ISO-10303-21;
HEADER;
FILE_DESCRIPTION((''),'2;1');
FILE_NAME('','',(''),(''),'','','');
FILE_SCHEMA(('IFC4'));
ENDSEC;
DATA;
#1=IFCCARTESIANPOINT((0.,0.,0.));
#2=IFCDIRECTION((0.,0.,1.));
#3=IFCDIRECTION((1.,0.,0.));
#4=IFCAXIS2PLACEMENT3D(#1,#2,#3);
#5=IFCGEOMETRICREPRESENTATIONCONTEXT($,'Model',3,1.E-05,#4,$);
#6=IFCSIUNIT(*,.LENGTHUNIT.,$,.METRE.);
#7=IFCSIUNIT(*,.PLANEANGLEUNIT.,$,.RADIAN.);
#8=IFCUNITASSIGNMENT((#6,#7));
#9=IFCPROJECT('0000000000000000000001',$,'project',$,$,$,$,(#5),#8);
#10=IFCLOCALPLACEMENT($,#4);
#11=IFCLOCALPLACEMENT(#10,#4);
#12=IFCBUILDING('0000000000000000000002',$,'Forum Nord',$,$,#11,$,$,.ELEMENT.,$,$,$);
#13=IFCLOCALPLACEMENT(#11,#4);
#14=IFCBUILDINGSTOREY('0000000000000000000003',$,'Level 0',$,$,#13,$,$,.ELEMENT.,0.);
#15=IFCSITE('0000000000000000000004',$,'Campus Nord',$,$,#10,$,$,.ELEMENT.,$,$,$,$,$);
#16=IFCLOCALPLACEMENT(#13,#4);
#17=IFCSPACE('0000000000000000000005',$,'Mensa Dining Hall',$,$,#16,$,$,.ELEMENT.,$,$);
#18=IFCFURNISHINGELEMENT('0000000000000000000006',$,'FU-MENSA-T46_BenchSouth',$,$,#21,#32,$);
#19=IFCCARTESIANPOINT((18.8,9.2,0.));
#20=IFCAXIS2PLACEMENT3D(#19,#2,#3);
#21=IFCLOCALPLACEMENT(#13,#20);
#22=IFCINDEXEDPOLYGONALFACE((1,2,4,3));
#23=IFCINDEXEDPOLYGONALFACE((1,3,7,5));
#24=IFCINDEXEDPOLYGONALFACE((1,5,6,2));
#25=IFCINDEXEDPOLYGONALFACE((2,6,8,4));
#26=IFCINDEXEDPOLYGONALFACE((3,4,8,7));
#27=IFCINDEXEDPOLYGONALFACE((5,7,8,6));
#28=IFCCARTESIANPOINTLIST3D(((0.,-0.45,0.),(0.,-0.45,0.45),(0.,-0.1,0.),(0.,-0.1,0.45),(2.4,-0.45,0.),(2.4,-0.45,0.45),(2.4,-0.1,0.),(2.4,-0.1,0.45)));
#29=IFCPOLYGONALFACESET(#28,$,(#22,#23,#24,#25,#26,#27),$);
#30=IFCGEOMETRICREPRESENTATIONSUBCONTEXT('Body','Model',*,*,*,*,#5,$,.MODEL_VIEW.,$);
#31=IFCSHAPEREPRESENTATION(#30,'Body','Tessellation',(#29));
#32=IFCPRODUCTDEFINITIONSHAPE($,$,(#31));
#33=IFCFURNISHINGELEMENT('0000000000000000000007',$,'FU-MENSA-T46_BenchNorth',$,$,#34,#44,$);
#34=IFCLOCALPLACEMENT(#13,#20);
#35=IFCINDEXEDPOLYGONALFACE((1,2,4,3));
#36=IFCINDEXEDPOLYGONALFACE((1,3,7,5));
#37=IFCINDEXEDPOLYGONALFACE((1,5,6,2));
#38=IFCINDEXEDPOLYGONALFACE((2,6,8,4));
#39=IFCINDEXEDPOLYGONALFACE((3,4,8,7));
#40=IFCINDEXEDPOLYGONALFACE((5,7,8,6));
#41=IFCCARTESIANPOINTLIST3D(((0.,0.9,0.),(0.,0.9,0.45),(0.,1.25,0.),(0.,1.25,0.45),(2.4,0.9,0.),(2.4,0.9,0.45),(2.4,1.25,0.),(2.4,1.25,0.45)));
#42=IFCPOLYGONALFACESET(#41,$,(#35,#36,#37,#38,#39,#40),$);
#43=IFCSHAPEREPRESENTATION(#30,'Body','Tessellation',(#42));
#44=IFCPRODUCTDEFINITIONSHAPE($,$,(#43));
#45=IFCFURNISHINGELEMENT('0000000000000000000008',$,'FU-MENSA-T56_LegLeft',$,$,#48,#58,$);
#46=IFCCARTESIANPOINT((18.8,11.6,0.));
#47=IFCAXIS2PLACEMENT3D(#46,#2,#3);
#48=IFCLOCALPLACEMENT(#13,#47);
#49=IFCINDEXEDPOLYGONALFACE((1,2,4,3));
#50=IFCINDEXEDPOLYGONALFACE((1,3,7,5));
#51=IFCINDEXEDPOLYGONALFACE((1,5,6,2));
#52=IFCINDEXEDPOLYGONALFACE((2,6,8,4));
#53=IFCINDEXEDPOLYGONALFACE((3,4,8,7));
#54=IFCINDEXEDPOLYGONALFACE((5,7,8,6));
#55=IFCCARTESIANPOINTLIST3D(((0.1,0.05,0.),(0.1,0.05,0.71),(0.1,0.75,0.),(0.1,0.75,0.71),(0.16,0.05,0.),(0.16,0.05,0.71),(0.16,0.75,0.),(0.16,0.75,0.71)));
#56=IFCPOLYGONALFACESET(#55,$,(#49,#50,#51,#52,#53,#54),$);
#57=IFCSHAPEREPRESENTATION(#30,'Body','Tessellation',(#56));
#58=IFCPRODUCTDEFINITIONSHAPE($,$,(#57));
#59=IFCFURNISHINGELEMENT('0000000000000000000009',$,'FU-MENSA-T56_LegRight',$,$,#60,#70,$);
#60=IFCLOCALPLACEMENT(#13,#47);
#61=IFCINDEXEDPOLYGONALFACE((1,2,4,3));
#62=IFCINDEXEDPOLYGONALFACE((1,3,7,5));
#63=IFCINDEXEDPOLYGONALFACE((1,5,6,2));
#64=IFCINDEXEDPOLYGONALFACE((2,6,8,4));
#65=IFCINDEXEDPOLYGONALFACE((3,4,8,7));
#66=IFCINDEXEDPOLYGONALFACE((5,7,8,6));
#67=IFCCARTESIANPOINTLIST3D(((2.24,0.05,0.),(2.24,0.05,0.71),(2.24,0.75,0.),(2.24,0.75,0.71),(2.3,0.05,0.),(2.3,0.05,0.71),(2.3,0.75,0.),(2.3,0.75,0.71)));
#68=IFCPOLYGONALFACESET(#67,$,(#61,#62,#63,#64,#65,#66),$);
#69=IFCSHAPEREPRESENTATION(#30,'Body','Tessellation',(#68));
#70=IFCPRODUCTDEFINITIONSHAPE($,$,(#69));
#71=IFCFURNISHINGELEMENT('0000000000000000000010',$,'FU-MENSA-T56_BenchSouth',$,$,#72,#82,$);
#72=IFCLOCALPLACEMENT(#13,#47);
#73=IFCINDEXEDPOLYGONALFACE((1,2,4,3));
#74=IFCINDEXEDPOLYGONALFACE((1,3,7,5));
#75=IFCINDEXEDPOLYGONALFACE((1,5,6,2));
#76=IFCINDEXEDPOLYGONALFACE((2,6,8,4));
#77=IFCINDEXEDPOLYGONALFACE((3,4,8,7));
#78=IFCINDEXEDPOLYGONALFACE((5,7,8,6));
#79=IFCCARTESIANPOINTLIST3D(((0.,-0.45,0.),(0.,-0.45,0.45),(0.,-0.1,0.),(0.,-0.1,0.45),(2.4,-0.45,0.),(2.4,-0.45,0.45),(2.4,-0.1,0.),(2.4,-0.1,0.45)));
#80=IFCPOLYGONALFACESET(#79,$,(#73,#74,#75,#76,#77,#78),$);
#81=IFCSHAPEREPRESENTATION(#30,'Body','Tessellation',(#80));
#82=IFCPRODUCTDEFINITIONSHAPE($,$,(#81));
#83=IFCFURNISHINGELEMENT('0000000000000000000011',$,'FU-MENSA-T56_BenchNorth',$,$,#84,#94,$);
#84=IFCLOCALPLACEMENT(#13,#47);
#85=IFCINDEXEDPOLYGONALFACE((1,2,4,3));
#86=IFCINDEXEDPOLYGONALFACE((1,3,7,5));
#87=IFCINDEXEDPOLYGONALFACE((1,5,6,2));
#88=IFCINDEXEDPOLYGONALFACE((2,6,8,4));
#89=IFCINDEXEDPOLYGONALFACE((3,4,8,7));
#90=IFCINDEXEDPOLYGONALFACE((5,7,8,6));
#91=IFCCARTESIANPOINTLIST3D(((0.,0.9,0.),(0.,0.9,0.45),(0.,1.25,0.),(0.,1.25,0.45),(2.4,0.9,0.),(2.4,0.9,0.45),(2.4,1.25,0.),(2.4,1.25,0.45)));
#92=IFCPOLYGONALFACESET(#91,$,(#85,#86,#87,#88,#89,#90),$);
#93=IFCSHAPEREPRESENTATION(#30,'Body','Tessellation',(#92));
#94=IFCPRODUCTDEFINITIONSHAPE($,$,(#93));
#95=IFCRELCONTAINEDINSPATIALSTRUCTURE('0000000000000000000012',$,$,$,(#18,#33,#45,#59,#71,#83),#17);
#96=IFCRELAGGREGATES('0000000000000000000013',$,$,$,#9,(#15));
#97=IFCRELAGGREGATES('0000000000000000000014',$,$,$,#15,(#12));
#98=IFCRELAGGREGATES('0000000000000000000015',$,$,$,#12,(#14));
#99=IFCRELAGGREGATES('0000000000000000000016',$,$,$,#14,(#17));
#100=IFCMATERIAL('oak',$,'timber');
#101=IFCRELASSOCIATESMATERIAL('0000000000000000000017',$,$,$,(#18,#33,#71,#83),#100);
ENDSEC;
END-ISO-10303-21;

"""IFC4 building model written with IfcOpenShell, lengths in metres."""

from ifc_helpers import new_model, si_unit, frame, frame_2d, origin_with_axes, place, context, subcontext, project, spatial, rectangle, extrude, material, element, save


model = new_model("IFC4")

# Units and contexts
model_context = context("Model", 3, precision=1e-05, world=origin_with_axes())
body_context = subcontext(model_context, "Body", "Model", "MODEL_VIEW")
ifc_project = project(units=[si_unit("LENGTHUNIT", "METRE"), si_unit("PLANEANGLEUNIT", "RADIAN")], contexts=[model_context])

# Site, building, storey
site_placement = place(None, origin_with_axes())
site = spatial("IfcSite", under=ifc_project, at=site_placement, Name="Campus Nord", CompositionType="ELEMENT")
building_placement = place(site_placement, origin_with_axes())
building = spatial("IfcBuilding", under=site, at=building_placement, Name="Forum Nord", CompositionType="ELEMENT")
storey_placement = place(building_placement, origin_with_axes())
storey = spatial("IfcBuildingStorey", under=building, at=storey_placement, Name="Level 0", CompositionType="ELEMENT", Elevation=0.0)

# Shared definitions
space_placement = place(storey_placement, origin_with_axes())
space = spatial("IfcSpace", under=storey, at=space_placement, Name="Mensa Dining Hall", CompositionType="ELEMENT")

# Furnishing elements
ifc_material_1 = material(Name="oak", Category="timber")
furnishing_1_placement = place(storey_placement, frame((18.8, 9.2, 0.0), z_axis=(0.0, 0.0, 1.0), x_axis=(1.0, 0.0, 0.0)))
element("IfcFurnishingElement", 1, at=furnishing_1_placement, inside=space, material=ifc_material_1, Name="FU-MENSA-T46_BenchSouth", context=body_context, shape_type="SweptSolid", body=[
    extrude(rectangle(XDim=2.4, YDim=0.35, at=frame_2d((1.2, -0.275), x_axis=(1.0, 0.0))), origin_with_axes(), (0.0, 0.0, 1.0), 0.45),
])
furnishing_2_placement = place(storey_placement, frame((18.8, 9.2, 0.0), z_axis=(0.0, 0.0, 1.0), x_axis=(1.0, 0.0, 0.0)))
element("IfcFurnishingElement", 2, at=furnishing_2_placement, inside=space, material=ifc_material_1, Name="FU-MENSA-T46_BenchNorth", context=body_context, shape_type="SweptSolid", body=[
    extrude(rectangle(XDim=2.4, YDim=0.35, at=frame_2d((1.2, 1.075), x_axis=(1.0, 0.0))), origin_with_axes(), (0.0, 0.0, 1.0), 0.45),
])
furnishing_3_placement = place(storey_placement, frame((18.8, 11.6, 0.0), z_axis=(0.0, 0.0, 1.0), x_axis=(1.0, 0.0, 0.0)))
element("IfcFurnishingElement", 3, at=furnishing_3_placement, inside=space, Name="FU-MENSA-T56_LegLeft", context=body_context, shape_type="SweptSolid", body=[
    extrude(rectangle(XDim=0.06, YDim=0.7, at=frame_2d((0.13, 0.4), x_axis=(1.0, 0.0))), origin_with_axes(), (0.0, 0.0, 1.0), 0.71),
])
furnishing_4_placement = place(storey_placement, frame((18.8, 11.6, 0.0), z_axis=(0.0, 0.0, 1.0), x_axis=(1.0, 0.0, 0.0)))
element("IfcFurnishingElement", 4, at=furnishing_4_placement, inside=space, Name="FU-MENSA-T56_LegRight", context=body_context, shape_type="SweptSolid", body=[
    extrude(rectangle(XDim=0.06, YDim=0.7, at=frame_2d((2.27, 0.4), x_axis=(1.0, 0.0))), origin_with_axes(), (0.0, 0.0, 1.0), 0.71),
])
furnishing_5_placement = place(storey_placement, frame((18.8, 11.6, 0.0), z_axis=(0.0, 0.0, 1.0), x_axis=(1.0, 0.0, 0.0)))
element("IfcFurnishingElement", 5, at=furnishing_5_placement, inside=space, material=ifc_material_1, Name="FU-MENSA-T56_BenchSouth", context=body_context, shape_type="SweptSolid", body=[
    extrude(rectangle(XDim=2.4, YDim=0.35, at=frame_2d((1.2, -0.275), x_axis=(1.0, 0.0))), origin_with_axes(), (0.0, 0.0, 1.0), 0.45),
])
furnishing_6_placement = place(storey_placement, frame((18.8, 11.6, 0.0), z_axis=(0.0, 0.0, 1.0), x_axis=(1.0, 0.0, 0.0)))
element("IfcFurnishingElement", 6, at=furnishing_6_placement, inside=space, material=ifc_material_1, Name="FU-MENSA-T56_BenchNorth", context=body_context, shape_type="SweptSolid", body=[
    extrude(rectangle(XDim=2.4, YDim=0.35, at=frame_2d((1.2, 1.075), x_axis=(1.0, 0.0))), origin_with_axes(), (0.0, 0.0, 1.0), 0.45),
])

save(model, "model.ifc")
